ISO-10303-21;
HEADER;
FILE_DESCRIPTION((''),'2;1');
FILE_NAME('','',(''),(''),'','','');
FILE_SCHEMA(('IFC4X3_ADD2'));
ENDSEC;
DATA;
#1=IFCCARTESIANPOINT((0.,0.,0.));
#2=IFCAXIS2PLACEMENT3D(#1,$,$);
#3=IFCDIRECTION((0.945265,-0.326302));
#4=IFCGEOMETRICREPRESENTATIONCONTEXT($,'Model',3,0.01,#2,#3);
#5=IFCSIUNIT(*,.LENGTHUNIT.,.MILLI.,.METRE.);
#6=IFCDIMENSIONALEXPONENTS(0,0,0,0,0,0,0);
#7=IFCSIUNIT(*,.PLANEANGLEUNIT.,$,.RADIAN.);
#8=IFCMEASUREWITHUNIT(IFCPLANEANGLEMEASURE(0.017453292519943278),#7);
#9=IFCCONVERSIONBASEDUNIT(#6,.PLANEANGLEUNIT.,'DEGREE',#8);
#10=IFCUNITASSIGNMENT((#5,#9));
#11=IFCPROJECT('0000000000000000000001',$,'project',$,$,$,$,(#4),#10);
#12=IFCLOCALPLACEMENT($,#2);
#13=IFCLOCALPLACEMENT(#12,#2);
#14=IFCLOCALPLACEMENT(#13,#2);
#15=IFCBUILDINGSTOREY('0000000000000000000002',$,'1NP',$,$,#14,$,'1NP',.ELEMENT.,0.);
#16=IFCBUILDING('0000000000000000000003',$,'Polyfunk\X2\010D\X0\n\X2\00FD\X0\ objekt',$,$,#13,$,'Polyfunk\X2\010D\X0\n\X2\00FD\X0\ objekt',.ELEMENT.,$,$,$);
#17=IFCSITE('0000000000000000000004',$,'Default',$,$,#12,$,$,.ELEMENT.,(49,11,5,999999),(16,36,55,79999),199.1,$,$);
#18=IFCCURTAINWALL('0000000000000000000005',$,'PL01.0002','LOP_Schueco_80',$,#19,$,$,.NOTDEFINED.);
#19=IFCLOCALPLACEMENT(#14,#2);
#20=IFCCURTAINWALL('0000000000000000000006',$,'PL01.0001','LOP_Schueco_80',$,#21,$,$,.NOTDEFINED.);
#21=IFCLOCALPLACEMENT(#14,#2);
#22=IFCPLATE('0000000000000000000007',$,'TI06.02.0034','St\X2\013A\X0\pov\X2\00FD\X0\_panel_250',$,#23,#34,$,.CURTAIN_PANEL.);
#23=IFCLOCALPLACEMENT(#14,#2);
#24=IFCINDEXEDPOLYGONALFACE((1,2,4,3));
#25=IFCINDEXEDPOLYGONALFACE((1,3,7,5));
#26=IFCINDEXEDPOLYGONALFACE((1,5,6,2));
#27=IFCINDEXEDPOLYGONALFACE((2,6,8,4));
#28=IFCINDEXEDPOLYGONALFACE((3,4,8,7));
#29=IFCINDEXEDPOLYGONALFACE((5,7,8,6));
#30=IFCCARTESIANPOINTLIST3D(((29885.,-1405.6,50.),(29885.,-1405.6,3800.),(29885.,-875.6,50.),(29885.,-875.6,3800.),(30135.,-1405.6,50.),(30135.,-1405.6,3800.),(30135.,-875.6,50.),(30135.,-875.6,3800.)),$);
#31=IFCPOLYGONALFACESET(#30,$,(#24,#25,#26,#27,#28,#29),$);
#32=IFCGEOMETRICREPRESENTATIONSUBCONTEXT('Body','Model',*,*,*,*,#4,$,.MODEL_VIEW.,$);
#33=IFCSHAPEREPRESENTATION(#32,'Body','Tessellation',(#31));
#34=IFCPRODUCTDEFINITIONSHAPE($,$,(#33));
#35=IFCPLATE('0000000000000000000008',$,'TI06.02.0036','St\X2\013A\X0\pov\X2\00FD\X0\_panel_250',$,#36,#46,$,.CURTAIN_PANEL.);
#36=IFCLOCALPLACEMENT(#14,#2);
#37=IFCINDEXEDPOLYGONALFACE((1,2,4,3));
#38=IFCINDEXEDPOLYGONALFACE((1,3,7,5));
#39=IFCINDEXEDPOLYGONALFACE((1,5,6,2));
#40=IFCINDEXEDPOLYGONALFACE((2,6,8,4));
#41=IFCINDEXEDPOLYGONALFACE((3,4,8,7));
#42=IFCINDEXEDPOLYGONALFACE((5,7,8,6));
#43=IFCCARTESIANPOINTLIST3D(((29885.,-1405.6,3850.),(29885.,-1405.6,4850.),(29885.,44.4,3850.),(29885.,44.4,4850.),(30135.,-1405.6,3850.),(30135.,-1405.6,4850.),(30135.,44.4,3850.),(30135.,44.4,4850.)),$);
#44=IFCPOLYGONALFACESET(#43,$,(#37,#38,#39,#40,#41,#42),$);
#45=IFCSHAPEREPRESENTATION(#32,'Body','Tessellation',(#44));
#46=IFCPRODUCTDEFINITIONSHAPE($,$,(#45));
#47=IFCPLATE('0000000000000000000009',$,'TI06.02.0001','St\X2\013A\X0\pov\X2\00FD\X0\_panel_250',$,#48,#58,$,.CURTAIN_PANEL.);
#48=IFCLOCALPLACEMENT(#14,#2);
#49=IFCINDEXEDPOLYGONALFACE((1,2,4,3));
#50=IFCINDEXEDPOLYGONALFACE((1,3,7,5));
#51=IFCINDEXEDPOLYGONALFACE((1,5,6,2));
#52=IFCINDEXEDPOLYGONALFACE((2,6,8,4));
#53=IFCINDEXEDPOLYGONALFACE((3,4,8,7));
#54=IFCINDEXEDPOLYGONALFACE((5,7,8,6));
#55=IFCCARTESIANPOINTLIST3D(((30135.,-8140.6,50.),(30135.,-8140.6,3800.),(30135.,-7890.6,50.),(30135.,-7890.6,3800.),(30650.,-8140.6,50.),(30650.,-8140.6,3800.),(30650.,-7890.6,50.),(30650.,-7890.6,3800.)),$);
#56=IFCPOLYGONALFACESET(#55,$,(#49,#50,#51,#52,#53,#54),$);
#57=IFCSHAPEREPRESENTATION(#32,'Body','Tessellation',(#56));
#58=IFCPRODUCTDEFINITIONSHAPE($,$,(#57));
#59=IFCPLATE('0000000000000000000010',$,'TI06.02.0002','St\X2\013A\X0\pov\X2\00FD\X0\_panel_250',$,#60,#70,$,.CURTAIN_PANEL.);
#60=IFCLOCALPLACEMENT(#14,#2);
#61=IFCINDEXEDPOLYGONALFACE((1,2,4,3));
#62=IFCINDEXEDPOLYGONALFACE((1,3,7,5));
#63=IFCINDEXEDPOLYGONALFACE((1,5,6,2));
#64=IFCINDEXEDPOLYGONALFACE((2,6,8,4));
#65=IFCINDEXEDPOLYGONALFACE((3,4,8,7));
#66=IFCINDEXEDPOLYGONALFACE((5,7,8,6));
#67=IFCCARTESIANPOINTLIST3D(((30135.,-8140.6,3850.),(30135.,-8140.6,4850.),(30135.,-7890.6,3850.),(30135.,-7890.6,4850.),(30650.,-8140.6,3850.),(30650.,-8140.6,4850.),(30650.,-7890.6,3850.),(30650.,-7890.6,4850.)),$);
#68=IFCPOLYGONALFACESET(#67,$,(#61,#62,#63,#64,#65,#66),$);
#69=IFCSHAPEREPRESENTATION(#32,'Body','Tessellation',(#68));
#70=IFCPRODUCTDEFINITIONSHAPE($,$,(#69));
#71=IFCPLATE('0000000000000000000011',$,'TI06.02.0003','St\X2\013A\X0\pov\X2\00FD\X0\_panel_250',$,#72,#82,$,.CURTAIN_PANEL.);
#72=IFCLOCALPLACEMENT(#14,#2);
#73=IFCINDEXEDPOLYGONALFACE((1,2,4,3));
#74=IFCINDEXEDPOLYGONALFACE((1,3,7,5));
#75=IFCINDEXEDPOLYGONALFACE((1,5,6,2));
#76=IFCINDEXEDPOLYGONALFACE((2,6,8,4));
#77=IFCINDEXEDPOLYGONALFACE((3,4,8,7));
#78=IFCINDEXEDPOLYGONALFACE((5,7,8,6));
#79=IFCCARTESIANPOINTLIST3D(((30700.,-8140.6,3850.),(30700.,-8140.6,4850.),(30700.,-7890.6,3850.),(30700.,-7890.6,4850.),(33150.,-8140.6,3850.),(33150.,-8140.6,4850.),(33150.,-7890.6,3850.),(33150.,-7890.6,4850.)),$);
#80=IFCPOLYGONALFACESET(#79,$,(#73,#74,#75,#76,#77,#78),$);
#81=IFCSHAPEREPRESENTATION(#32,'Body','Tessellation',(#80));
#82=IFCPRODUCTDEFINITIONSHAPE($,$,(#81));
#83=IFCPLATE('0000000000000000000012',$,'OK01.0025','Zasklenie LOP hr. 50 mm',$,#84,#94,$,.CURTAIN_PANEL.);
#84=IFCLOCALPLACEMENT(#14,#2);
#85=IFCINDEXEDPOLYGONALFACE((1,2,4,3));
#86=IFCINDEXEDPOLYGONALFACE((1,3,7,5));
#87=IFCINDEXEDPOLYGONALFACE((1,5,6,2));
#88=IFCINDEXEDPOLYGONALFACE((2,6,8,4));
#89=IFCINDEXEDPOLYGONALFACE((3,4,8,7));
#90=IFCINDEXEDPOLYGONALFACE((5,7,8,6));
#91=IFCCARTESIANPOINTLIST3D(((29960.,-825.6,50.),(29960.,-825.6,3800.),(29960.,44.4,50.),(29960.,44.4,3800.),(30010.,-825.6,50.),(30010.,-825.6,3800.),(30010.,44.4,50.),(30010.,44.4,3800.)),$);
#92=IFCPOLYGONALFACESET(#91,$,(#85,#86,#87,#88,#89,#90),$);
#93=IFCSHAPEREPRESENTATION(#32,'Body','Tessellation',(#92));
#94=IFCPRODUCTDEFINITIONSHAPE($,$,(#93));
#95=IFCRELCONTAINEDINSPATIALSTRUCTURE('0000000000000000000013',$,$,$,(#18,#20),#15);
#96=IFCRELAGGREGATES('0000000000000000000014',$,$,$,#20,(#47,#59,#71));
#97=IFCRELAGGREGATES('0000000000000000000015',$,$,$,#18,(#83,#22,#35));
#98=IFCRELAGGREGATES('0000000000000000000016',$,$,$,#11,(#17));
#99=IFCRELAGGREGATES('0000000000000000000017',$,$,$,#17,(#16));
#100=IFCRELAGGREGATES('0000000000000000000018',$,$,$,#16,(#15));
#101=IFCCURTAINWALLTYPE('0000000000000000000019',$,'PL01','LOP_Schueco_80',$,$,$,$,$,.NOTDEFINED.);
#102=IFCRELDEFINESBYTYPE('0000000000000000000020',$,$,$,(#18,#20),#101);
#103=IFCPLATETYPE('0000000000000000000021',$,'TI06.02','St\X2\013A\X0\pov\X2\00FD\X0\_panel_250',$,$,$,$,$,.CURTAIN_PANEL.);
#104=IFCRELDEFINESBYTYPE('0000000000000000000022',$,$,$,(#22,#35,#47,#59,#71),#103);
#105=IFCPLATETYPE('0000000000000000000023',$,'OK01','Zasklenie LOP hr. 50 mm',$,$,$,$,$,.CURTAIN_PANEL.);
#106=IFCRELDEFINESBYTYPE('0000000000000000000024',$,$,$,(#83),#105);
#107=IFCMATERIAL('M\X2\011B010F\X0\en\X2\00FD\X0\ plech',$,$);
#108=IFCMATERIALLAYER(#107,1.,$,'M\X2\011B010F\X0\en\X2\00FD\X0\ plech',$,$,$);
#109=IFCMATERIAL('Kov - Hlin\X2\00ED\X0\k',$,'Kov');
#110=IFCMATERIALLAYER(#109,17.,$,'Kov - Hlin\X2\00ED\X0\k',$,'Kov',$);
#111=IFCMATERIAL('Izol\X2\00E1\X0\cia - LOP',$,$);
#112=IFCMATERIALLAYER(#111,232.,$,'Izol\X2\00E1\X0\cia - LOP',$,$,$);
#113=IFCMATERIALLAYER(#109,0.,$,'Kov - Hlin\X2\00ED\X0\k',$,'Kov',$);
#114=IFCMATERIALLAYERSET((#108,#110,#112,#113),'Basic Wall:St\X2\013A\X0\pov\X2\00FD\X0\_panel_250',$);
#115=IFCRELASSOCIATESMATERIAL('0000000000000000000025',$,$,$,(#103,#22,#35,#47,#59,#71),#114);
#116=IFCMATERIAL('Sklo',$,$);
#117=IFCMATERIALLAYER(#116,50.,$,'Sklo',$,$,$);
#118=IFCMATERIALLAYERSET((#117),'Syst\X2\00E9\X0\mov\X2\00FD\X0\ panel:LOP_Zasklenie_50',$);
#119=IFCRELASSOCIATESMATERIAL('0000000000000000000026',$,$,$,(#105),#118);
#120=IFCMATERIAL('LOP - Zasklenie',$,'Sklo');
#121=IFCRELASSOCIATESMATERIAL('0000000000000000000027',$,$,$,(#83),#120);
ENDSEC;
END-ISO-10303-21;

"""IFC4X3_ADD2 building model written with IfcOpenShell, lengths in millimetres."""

from ifc_helpers import new_model, entity, si_unit, converted_unit, direction, frame, frame_2d, origin, place, context, subcontext, project, spatial, rectangle, extrude, source, transform, mapped, material, layer, layer_set, layer_usage, type_object, type_shapes, element, aggregate, save


model = new_model("IFC4X3_ADD2")

# Units and contexts
model_context = context("Model", 3, precision=0.01, world=origin(), true_north=direction((0.945265, -0.326302)))
body_context = subcontext(model_context, "Body", "Model", "MODEL_VIEW")
ifc_project = project(units=[si_unit("LENGTHUNIT", "METRE", prefix="MILLI"), converted_unit("PLANEANGLEUNIT", "DEGREE", entity("IfcPlaneAngleMeasure", 0.017453292519943278), si_unit("PLANEANGLEUNIT", "RADIAN"), dimensions=[0, 0, 0, 0, 0, 0, 0])], contexts=[model_context])

# Site, building, storey
site_placement = place(None, origin())
site = spatial("IfcSite", under=ifc_project, at=site_placement, Name="Default", CompositionType="ELEMENT", RefLatitude=(49, 11, 5, 999999), RefLongitude=(16, 36, 55, 79999), RefElevation=199.1)
building_placement = place(site_placement, origin())
building = spatial("IfcBuilding", under=site, at=building_placement, Name="Polyfunkčný objekt", LongName="Polyfunkčný objekt", CompositionType="ELEMENT")
storey_placement = place(building_placement, origin())
storey = spatial("IfcBuildingStorey", under=building, at=storey_placement, Name="1NP", LongName="1NP", CompositionType="ELEMENT", Elevation=0.0)

# Curtain wall
curtain_wall_type = type_object("IfcCurtainWallType", Name="PL01", Description="LOP_Schueco_80", PredefinedType="NOTDEFINED")
curtain_wall_1_placement = place(storey_placement, origin())
curtain_wall_1 = element("IfcCurtainWall", 1, at=curtain_wall_1_placement, inside=storey, type_object=curtain_wall_type, Name="PL01.0002", Description="LOP_Schueco_80", PredefinedType="NOTDEFINED")

# Curtain wall
curtain_wall_2_placement = place(storey_placement, origin())
curtain_wall_2 = element("IfcCurtainWall", 2, at=curtain_wall_2_placement, inside=storey, type_object=curtain_wall_type, Name="PL01.0001", Description="LOP_Schueco_80", PredefinedType="NOTDEFINED")

# Plates
ifc_material_1 = material(Name="Měďený plech")
ifc_layer_1 = layer(ifc_material_1, 1.0, Name="Měďený plech")
ifc_material_2 = material(Name="Kov - Hliník", Category="Kov")
ifc_layer_2 = layer(ifc_material_2, 17.0, Name="Kov - Hliník", Category="Kov")
ifc_material_3 = material(Name="Izolácia - LOP")
ifc_layer_3 = layer(ifc_material_3, 232.0, Name="Izolácia - LOP")
ifc_layer_4 = layer(ifc_material_2, 0.0, Name="Kov - Hliník", Category="Kov")
ifc_layer_set_1 = layer_set([ifc_layer_1, ifc_layer_2, ifc_layer_3, ifc_layer_4], Name="Basic Wall:Stĺpový_panel_250")
ifc_layer_usage_1 = layer_usage(ifc_layer_set_1, "AXIS2", "POSITIVE", -125.0)
plate_type_1 = type_object("IfcPlateType", Name="TI06.02", Description="Stĺpový_panel_250", PredefinedType="CURTAIN_PANEL", material=ifc_layer_set_1)
plate_1_placement = place(storey_placement, frame((30010.0, -875.6, 50.0), z_axis=(0.0, 0.0, 1.0), x_axis=(0.0, -1.0, 0.0)))
plate_1 = element("IfcPlate", 3, at=plate_1_placement, type_object=plate_type_1, material=ifc_layer_usage_1, Name="TI06.02.0034", Description="Stĺpový_panel_250", PredefinedType="CURTAIN_PANEL", context=body_context, shape_type="SweptSolid", body=[
    extrude(rectangle(XDim=250.0, YDim=530.0, at=frame_2d((0.0, 0.0), x_axis=(1.0, 0.0))), frame((265.0, 0.0, 0.0), z_axis=(0.0, 0.0, 1.0), x_axis=(0.0, 1.0, 0.0)), (0.0, 0.0, 1.0), 3750.0),
])
ifc_layer_usage_2 = layer_usage(ifc_layer_set_1, "AXIS2", "POSITIVE", -125.0)
plate_2_placement = place(storey_placement, frame((30010.0, 44.4, 3850.0), z_axis=(0.0, 0.0, 1.0), x_axis=(0.0, -1.0, 0.0)))
plate_2 = element("IfcPlate", 4, at=plate_2_placement, type_object=plate_type_1, material=ifc_layer_usage_2, Name="TI06.02.0036", Description="Stĺpový_panel_250", PredefinedType="CURTAIN_PANEL", context=body_context, shape_type="SweptSolid", body=[
    extrude(rectangle(XDim=250.0, YDim=1450.0, at=frame_2d((0.0, 0.0), x_axis=(1.0, 0.0))), frame((725.0, 0.0, 0.0), z_axis=(0.0, 0.0, 1.0), x_axis=(0.0, 1.0, 0.0)), (0.0, 0.0, 1.0), 1000.0),
])
ifc_layer_usage_3 = layer_usage(ifc_layer_set_1, "AXIS2", "POSITIVE", -125.0)
plate_3_placement = place(storey_placement, frame((30135.0, -8015.6, 50.0)))
plate_3 = element("IfcPlate", 5, at=plate_3_placement, type_object=plate_type_1, material=ifc_layer_usage_3, Name="TI06.02.0001", Description="Stĺpový_panel_250", PredefinedType="CURTAIN_PANEL", context=body_context, shape_type="SweptSolid", body=[
    extrude(rectangle(XDim=250.0, YDim=515.0, at=frame_2d((0.0, 0.0), x_axis=(1.0, 0.0))), frame((257.5, 0.0, 0.0), z_axis=(0.0, 0.0, 1.0), x_axis=(0.0, 1.0, 0.0)), (0.0, 0.0, 1.0), 3750.0),
])
ifc_layer_usage_4 = layer_usage(ifc_layer_set_1, "AXIS2", "POSITIVE", -125.0)
plate_4_placement = place(storey_placement, frame((30135.0, -8015.6, 3850.0)))
plate_4 = element("IfcPlate", 6, at=plate_4_placement, type_object=plate_type_1, material=ifc_layer_usage_4, Name="TI06.02.0002", Description="Stĺpový_panel_250", PredefinedType="CURTAIN_PANEL", context=body_context, shape_type="SweptSolid", body=[
    extrude(rectangle(XDim=250.0, YDim=515.0, at=frame_2d((0.0, 0.0), x_axis=(1.0, 0.0))), frame((257.5, 0.0, 0.0), z_axis=(0.0, 0.0, 1.0), x_axis=(0.0, 1.0, 0.0)), (0.0, 0.0, 1.0), 1000.0),
])
ifc_layer_usage_5 = layer_usage(ifc_layer_set_1, "AXIS2", "POSITIVE", -125.0)
plate_5_placement = place(storey_placement, frame((30700.0, -8015.6, 3850.0)))
plate_5 = element("IfcPlate", 7, at=plate_5_placement, type_object=plate_type_1, material=ifc_layer_usage_5, Name="TI06.02.0003", Description="Stĺpový_panel_250", PredefinedType="CURTAIN_PANEL", context=body_context, shape_type="SweptSolid", body=[
    extrude(rectangle(XDim=250.0, YDim=2450.0, at=frame_2d((0.0, 0.0), x_axis=(1.0, 0.0))), frame((1225.0, 0.0, 0.0), z_axis=(0.0, 0.0, 1.0), x_axis=(0.0, 1.0, 0.0)), (0.0, 0.0, 1.0), 1000.0),
])
aggregate(curtain_wall_2, [plate_3, plate_4, plate_5])
ifc_material_4 = material(Name="LOP - Zasklenie", Category="Sklo")
ifc_material_5 = material(Name="Sklo")
ifc_layer_5 = layer(ifc_material_5, 50.0, Name="Sklo")
ifc_layer_set_2 = layer_set([ifc_layer_5], Name="Systémový panel:LOP_Zasklenie_50")
plate_type_2 = type_object("IfcPlateType", Name="OK01", Description="Zasklenie LOP hr. 50 mm", PredefinedType="CURTAIN_PANEL", material=ifc_layer_set_2)
shared_shape_1 = source(origin(), body_context, "Body", "SweptSolid", [
    extrude(rectangle(XDim=3750.0, YDim=870.0, at=frame_2d((-141.7, 0.0), x_axis=(1.0, 0.0))), frame((0.0, -50.0, 2016.7), z_axis=(0.0, 1.0, 0.0), x_axis=(0.0, 0.0, 1.0)), (0.0, 0.0, 1.0), 50.0),
])
type_shapes(plate_type_2, [shared_shape_1])
plate_6_placement = place(curtain_wall_1_placement, frame((30010.0, -390.6, 50.0), z_axis=(0.0, 0.0, 1.0), x_axis=(0.0, -1.0, 0.0)))
plate_6 = element("IfcPlate", 8, at=plate_6_placement, type_object=plate_type_2, material=ifc_material_4, Name="OK01.0025", Description="Zasklenie LOP hr. 50 mm", PredefinedType="CURTAIN_PANEL", context=body_context, shape_type="MappedRepresentation", body=[
    mapped(shared_shape_1, transform((0.0, 0.0, 0.0), scale=1.0)),
])
aggregate(curtain_wall_1, [plate_6, plate_1, plate_2])

save(model, "model.ifc")
